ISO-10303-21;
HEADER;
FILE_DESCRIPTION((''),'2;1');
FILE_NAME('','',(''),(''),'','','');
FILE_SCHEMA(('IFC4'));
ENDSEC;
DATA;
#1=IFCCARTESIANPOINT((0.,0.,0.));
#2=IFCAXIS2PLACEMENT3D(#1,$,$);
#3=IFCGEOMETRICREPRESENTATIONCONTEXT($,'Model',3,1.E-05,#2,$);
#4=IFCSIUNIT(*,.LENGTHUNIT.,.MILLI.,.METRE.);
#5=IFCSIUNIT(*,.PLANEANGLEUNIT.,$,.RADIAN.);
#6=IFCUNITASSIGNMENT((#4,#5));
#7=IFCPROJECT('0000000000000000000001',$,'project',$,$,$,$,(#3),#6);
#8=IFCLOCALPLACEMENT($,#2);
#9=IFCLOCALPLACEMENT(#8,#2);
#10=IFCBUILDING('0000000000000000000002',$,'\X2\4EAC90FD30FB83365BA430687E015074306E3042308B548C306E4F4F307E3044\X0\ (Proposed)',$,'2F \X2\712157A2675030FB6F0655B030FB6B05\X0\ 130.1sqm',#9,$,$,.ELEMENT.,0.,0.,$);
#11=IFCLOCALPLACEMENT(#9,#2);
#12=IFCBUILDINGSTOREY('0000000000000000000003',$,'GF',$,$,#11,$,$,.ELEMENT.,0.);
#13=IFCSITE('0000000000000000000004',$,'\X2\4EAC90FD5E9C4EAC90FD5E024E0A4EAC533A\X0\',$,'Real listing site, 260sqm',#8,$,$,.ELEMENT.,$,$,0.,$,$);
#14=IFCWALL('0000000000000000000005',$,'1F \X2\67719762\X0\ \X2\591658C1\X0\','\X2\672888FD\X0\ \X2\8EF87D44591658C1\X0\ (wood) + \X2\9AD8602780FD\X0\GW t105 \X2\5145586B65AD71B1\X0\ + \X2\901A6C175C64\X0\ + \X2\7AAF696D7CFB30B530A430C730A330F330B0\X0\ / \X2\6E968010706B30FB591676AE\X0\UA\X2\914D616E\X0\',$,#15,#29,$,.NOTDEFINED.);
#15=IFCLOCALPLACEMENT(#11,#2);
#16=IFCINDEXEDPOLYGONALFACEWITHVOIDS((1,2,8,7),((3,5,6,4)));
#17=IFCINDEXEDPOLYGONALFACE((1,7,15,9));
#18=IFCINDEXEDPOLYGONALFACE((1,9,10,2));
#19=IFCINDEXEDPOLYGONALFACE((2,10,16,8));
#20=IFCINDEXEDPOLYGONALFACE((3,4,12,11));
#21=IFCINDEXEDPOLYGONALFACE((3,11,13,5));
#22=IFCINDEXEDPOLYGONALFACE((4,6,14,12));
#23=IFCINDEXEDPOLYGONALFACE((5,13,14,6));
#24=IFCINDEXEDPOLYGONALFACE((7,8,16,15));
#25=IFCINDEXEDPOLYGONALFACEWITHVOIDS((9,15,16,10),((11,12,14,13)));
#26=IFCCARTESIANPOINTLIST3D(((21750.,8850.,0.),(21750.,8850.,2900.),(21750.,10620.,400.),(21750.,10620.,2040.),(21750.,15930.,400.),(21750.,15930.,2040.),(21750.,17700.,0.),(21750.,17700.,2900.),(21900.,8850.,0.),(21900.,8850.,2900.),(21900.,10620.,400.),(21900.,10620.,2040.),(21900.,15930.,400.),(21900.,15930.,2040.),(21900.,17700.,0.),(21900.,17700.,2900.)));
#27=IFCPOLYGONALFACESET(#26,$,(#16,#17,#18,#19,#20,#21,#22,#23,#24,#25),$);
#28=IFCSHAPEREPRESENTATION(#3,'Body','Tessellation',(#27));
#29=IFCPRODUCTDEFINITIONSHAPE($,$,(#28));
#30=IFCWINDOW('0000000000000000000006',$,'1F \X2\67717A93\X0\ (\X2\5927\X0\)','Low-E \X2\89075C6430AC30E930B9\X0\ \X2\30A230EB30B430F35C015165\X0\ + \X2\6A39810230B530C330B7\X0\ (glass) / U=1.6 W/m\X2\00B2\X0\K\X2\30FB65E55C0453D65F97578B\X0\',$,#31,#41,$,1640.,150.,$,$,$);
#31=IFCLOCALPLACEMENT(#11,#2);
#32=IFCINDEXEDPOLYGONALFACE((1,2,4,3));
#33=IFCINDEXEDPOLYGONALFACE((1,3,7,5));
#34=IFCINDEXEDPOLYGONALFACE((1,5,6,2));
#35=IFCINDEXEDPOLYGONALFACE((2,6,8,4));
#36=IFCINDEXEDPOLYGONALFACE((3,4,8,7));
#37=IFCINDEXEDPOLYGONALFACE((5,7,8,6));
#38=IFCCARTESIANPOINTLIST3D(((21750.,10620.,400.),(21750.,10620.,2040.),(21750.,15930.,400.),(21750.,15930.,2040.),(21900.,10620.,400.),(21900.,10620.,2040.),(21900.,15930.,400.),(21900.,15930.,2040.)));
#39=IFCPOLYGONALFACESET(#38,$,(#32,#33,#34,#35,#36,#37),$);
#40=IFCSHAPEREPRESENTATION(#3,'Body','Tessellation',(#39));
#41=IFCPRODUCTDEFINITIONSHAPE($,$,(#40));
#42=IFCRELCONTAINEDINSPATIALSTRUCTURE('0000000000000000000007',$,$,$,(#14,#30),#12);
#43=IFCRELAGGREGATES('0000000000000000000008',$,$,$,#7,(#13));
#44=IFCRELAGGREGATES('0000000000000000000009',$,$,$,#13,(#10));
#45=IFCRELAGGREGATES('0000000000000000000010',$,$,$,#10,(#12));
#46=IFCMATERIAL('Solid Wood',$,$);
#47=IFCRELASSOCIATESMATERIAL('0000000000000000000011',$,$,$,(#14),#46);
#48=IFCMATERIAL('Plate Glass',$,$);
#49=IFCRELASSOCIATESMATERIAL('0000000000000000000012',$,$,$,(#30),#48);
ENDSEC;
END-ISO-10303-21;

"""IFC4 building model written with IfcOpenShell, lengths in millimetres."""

from ifc_helpers import new_model, si_unit, frame, frame_2d, origin, place, context, project, spatial, rectangle, extrude, material, element, fill, save


model = new_model("IFC4")

# Units and contexts
model_context = context("Model", 3, precision=1e-05, world=origin())
ifc_project = project(units=[si_unit("LENGTHUNIT", "METRE", prefix="MILLI"), si_unit("PLANEANGLEUNIT", "RADIAN")], contexts=[model_context])

# Site, building, storey
site_placement = place(None, origin())
site = spatial("IfcSite", under=ifc_project, at=site_placement, Name="京都府京都市上京区", ObjectType="Real listing site, 260sqm", CompositionType="ELEMENT", RefElevation=0.0)
building_placement = place(site_placement, origin())
building = spatial("IfcBuilding", under=site, at=building_placement, Name="京都・茶室と縁側のある和の住まい (Proposed)", ObjectType="2F 無垢材・漆喰・欅 130.1sqm", CompositionType="ELEMENT", ElevationOfRefHeight=0.0, ElevationOfTerrain=0.0)
storey_placement = place(building_placement, origin())
storey = spatial("IfcBuildingStorey", under=building, at=storey_placement, Name="GF", CompositionType="ELEMENT", Elevation=0.0)

# Shared definitions
ifc_material_1 = material(Name="Solid Wood")

# Wall, opening, window
wall_1_placement = place(storey_placement, frame((10875.0, 4425.0, 0.0)))
wall_1 = element("IfcWall", 1, at=wall_1_placement, inside=storey, material=ifc_material_1, Name="1F 東面 外壁", Description="木製 軸組外壁 (wood) + 高性能GW t105 充填断熱 + 通気層 + 窯業系サイディング / 準耐火・外皮UA配慮", PredefinedType="NOTDEFINED", context=model_context, shape_type="SweptSolid", body=[
    extrude(rectangle(XDim=150.0, YDim=8850.0, at=frame_2d((75.0, 4425.0))), frame((10875.0, 4425.0, 0.0)), (0.0, 0.0, 1.0), 2900.0),
])
opening_1_placement = place(storey_placement, frame((10875.0, 5310.0, 200.0)))
opening_1 = element("IfcOpeningElement", 2, at=opening_1_placement, cuts=wall_1, PredefinedType="NOTDEFINED", context=model_context, shape_type="SweptSolid", body=[
    extrude(rectangle(XDim=150.0, YDim=5310.0, at=frame_2d((75.0, 2655.0))), frame((10875.0, 5310.0, 200.0)), (0.0, 0.0, 1.0), 1640.0),
])
ifc_material_2 = material(Name="Plate Glass")
window_1_placement = place(storey_placement, frame((10875.0, 5310.0, 200.0)))
window_1 = element("IfcWindow", 3, at=window_1_placement, inside=storey, material=ifc_material_2, Name="1F 東窓 (大)", Description="Low-E 複層ガラス アルゴン封入 + 樹脂サッシ (glass) / U=1.6 W/m²K・日射取得型", OverallHeight=1640.0, OverallWidth=150.0, context=model_context, shape_type="SweptSolid", body=[
    extrude(rectangle(XDim=150.0, YDim=5310.0, at=frame_2d((75.0, 2655.0))), frame((10875.0, 5310.0, 200.0)), (0.0, 0.0, 1.0), 1640.0),
])
fill(opening_1, window_1)

save(model, "model.ifc")
